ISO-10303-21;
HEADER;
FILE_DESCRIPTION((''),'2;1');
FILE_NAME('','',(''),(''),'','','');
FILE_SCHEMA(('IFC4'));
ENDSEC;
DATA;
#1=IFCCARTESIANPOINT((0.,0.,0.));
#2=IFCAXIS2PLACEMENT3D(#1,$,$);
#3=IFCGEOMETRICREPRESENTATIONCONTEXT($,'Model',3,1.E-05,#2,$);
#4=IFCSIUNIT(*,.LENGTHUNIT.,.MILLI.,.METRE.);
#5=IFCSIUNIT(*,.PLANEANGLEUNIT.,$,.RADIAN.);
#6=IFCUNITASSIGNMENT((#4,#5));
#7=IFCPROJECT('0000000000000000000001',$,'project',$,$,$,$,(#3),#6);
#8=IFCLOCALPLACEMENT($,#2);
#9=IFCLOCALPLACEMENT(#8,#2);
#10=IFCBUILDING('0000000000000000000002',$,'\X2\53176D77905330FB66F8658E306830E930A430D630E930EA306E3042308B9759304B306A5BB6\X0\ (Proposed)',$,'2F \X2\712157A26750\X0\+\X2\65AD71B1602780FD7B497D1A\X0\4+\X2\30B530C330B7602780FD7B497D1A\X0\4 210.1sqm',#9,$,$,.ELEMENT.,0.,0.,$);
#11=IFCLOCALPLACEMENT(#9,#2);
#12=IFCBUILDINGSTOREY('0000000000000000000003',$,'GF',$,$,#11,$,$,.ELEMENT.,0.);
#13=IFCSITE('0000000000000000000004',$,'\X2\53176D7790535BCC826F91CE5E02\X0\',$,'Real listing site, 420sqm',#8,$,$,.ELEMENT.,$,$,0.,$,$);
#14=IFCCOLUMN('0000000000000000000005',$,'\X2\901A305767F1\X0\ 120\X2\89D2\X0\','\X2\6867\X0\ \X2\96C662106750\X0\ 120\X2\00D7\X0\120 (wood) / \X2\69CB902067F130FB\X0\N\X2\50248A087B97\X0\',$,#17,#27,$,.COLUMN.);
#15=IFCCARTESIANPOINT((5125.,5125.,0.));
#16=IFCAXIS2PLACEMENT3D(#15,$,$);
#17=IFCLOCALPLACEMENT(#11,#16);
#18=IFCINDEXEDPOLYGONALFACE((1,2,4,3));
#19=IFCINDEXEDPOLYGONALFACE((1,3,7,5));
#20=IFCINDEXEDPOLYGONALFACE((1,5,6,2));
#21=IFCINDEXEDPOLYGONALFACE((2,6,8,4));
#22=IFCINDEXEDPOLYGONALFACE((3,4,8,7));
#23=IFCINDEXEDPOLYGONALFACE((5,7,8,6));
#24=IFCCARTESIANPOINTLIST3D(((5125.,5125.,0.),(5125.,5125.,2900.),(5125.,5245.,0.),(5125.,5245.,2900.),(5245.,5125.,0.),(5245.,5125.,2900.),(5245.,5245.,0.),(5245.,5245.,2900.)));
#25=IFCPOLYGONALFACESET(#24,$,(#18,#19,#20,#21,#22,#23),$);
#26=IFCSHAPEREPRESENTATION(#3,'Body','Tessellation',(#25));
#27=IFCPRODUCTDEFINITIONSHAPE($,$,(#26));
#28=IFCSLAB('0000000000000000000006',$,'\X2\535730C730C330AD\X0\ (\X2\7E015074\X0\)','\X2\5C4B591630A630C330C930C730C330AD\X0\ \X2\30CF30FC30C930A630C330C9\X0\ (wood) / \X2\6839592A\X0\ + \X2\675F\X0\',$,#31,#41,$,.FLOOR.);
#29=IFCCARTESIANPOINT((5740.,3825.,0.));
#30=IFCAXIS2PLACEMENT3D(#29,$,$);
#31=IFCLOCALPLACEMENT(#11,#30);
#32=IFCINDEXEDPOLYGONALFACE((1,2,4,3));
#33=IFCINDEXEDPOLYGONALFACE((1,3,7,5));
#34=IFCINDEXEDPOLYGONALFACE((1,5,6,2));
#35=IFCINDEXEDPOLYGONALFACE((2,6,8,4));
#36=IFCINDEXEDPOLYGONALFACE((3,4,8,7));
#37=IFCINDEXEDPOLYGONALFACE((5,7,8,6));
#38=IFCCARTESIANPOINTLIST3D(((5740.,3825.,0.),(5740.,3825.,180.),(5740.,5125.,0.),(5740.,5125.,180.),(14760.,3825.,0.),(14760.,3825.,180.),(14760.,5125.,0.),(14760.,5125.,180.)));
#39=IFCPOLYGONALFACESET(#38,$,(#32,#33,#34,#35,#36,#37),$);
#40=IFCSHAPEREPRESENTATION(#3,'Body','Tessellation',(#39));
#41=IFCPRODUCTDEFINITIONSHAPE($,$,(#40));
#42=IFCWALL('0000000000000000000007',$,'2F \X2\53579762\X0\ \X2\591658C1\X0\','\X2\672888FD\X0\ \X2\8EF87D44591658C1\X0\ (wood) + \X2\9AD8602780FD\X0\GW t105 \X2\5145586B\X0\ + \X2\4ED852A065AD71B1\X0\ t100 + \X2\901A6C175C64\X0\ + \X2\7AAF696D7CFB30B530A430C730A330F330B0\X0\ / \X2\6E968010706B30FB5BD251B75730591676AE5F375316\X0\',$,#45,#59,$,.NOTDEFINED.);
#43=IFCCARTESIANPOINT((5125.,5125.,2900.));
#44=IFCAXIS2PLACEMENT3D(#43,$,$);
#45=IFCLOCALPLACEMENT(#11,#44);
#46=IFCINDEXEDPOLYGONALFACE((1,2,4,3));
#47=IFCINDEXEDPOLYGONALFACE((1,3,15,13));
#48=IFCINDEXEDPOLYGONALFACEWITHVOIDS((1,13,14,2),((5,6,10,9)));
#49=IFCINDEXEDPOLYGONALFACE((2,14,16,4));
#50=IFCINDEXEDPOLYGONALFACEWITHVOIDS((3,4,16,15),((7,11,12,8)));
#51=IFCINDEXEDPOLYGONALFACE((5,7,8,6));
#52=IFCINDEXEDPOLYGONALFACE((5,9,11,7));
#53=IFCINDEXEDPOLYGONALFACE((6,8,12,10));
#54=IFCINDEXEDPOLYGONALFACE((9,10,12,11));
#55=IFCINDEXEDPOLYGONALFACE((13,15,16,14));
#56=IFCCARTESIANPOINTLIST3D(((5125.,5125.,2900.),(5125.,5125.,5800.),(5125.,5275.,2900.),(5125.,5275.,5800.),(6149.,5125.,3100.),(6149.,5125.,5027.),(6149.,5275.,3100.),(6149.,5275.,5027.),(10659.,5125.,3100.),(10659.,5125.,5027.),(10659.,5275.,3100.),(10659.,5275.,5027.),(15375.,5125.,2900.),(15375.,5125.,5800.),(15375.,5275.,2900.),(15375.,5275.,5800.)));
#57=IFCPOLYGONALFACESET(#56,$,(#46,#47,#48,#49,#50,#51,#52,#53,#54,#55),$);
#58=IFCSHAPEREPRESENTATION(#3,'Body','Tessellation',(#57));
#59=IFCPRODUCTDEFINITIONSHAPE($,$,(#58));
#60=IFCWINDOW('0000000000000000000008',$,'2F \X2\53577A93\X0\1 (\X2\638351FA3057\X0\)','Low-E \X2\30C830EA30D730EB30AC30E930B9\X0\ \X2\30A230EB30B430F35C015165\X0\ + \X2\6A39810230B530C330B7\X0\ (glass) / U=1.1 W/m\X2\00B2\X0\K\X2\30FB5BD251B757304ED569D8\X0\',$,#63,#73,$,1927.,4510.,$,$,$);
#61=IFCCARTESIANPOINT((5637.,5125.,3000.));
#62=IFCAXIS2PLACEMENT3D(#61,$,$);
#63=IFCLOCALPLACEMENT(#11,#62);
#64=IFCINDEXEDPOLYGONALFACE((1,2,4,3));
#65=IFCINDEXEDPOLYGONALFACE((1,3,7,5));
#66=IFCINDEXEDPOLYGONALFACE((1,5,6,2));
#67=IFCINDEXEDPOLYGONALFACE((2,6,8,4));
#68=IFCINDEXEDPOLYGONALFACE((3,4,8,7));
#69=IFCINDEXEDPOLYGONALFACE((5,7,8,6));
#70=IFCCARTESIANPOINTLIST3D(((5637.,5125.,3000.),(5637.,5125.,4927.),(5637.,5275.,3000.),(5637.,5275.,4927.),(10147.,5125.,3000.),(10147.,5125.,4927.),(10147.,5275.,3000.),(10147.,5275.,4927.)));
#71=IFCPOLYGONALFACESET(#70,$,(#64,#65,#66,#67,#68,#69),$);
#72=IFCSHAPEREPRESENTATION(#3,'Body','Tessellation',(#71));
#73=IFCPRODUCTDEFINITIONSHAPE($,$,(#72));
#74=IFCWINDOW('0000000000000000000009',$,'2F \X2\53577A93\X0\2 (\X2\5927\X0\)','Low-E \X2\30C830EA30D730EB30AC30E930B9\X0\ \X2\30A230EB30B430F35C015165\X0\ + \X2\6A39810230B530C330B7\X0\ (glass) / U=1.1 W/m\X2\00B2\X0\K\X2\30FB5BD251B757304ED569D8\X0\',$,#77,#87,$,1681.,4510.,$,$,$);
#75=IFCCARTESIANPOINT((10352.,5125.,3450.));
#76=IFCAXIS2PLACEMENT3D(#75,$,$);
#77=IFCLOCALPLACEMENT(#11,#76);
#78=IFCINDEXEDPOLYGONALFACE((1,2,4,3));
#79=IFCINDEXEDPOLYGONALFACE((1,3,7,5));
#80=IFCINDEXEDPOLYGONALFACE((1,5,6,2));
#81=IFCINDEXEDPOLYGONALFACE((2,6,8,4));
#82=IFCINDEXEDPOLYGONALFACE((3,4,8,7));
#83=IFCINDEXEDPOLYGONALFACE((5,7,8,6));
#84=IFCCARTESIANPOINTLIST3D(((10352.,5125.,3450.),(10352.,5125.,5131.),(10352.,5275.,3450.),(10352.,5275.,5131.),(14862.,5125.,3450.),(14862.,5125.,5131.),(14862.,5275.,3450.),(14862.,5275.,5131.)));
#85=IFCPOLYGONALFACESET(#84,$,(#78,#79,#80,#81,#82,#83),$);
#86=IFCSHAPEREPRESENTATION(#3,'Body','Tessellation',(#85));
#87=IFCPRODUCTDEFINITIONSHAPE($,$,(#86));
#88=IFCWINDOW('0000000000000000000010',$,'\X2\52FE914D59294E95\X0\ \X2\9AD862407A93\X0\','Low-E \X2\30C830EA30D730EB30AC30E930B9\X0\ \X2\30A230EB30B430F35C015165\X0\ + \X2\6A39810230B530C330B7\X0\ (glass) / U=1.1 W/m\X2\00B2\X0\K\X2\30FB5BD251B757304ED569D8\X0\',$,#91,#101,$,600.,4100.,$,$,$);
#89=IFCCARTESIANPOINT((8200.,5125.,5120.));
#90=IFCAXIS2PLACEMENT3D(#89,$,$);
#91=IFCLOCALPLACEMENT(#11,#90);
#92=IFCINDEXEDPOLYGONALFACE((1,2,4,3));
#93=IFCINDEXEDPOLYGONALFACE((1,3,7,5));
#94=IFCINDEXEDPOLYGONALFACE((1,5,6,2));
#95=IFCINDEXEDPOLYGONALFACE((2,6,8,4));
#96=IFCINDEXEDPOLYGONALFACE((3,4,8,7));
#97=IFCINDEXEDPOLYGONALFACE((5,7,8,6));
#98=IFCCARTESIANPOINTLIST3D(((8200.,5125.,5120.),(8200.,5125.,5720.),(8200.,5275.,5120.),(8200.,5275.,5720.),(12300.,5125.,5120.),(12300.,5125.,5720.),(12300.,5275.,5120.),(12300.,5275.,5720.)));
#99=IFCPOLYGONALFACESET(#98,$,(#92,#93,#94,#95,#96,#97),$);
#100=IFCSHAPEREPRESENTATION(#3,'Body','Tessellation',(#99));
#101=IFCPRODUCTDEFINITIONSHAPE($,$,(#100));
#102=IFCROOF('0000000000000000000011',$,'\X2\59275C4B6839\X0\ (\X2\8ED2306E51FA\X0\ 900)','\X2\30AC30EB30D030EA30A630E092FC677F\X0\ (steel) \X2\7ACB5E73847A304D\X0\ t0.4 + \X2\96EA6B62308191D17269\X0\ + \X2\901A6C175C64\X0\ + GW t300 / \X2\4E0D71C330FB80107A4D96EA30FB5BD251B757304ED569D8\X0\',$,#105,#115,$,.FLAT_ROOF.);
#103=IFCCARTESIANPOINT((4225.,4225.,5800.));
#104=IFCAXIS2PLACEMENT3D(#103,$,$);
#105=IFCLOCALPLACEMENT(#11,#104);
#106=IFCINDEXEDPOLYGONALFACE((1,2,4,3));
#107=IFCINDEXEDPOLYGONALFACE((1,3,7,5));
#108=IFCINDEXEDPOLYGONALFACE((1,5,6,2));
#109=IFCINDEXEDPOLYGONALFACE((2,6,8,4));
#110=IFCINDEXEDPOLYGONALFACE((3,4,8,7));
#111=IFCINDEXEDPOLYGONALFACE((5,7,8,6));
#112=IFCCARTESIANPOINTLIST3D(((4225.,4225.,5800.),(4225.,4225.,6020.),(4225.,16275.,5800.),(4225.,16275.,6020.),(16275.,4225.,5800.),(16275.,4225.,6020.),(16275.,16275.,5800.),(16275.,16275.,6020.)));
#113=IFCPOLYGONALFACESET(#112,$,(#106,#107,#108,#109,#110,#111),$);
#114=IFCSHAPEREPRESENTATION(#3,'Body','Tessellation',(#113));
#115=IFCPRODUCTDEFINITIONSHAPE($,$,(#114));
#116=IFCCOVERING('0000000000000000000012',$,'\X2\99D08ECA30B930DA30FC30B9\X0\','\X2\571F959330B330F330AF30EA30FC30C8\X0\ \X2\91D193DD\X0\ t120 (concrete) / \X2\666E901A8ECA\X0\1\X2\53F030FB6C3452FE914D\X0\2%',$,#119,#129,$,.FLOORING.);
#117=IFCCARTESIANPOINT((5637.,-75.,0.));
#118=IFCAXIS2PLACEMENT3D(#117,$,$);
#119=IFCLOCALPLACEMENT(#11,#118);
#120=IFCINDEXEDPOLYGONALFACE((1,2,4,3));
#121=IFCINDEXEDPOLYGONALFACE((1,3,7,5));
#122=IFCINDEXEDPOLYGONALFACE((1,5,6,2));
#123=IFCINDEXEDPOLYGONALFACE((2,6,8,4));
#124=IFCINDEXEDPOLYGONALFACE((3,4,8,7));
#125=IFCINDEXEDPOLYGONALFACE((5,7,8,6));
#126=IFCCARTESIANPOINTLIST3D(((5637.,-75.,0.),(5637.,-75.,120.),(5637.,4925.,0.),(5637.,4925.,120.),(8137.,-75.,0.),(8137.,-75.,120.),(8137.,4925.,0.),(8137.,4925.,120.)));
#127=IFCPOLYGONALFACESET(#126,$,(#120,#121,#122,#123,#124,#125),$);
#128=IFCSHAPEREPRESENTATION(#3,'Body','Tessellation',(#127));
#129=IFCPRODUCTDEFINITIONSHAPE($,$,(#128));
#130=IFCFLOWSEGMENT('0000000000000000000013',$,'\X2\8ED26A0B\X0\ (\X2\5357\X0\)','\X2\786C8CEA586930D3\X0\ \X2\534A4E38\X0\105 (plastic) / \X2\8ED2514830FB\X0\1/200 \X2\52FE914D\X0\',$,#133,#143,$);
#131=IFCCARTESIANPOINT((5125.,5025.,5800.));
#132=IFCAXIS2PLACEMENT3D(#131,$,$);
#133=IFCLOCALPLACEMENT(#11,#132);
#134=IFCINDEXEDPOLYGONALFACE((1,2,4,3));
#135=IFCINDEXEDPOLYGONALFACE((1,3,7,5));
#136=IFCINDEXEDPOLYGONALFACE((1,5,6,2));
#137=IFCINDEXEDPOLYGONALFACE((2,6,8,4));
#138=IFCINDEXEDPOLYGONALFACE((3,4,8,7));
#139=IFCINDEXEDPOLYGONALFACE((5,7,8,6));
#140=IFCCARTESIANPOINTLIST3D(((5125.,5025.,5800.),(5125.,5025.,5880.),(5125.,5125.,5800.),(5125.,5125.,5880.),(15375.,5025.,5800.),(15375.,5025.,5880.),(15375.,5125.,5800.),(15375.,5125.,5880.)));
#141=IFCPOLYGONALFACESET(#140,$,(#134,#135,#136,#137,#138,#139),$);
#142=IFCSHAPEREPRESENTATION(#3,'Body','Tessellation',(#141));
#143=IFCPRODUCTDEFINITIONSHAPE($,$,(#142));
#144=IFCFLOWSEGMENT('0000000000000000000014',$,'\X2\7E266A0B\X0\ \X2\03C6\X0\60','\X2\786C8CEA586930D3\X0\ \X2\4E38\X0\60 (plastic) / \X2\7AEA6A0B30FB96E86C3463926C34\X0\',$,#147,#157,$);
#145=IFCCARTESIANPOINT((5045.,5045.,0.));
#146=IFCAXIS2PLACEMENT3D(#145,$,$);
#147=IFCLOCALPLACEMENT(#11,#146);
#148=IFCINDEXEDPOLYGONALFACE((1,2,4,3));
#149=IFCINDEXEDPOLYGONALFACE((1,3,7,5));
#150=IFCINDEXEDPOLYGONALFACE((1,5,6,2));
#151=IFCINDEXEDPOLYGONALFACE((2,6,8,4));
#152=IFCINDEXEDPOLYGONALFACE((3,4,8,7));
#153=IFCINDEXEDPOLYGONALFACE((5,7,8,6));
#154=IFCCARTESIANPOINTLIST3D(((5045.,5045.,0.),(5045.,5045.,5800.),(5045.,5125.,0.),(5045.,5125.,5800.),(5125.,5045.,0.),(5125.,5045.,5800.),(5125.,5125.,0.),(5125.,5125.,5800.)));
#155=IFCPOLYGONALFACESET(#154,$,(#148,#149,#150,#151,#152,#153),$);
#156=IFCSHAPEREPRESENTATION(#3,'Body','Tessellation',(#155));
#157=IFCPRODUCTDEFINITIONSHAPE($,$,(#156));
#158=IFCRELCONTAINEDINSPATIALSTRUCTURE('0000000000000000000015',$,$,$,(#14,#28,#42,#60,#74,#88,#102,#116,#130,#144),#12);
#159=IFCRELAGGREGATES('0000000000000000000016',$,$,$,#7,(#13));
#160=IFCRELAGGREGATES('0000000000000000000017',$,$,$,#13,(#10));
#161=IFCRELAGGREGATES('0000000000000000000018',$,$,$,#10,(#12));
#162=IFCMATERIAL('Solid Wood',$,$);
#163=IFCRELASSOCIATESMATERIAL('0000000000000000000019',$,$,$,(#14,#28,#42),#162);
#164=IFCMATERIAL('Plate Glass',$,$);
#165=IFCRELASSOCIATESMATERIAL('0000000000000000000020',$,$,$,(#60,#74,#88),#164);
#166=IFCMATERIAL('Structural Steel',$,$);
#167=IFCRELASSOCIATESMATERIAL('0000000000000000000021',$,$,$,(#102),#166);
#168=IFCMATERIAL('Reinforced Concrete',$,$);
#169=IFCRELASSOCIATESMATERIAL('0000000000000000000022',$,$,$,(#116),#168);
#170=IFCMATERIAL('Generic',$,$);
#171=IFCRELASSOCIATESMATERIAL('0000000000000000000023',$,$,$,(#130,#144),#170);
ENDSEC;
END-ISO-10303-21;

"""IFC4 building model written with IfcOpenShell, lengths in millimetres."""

from ifc_helpers import new_model, si_unit, frame, frame_2d, origin, place, context, project, spatial, rectangle, extrude, material, element, fill, save


model = new_model("IFC4")

# Units and contexts
model_context = context("Model", 3, precision=1e-05, world=origin())
ifc_project = project(units=[si_unit("LENGTHUNIT", "METRE", prefix="MILLI"), si_unit("PLANEANGLEUNIT", "RADIAN")], contexts=[model_context])

# Site, building, storey
site_placement = place(None, origin())
site = spatial("IfcSite", under=ifc_project, at=site_placement, Name="北海道富良野市", ObjectType="Real listing site, 420sqm", CompositionType="ELEMENT", RefElevation=0.0)
building_placement = place(site_placement, origin())
building = spatial("IfcBuilding", under=site, at=building_placement, Name="北海道・書斎とライブラリのある静かな家 (Proposed)", ObjectType="2F 無垢材+断熱性能等級4+サッシ性能等級4 210.1sqm", CompositionType="ELEMENT", ElevationOfRefHeight=0.0, ElevationOfTerrain=0.0)
storey_placement = place(building_placement, origin())
storey = spatial("IfcBuildingStorey", under=building, at=storey_placement, Name="GF", CompositionType="ELEMENT", Elevation=0.0)

# Column
ifc_material_1 = material(Name="Solid Wood")
column_placement = place(storey_placement, frame((5125.0, 5125.0, 0.0)))
element("IfcColumn", 1, at=column_placement, inside=storey, material=ifc_material_1, Name="通し柱 120角", Description="桧 集成材 120×120 (wood) / 構造柱・N値計算", PredefinedType="COLUMN", context=model_context, shape_type="SweptSolid", body=[
    extrude(rectangle(XDim=120.0, YDim=120.0, at=frame_2d((60.0, 60.0))), frame((5125.0, 5125.0, 0.0)), (0.0, 0.0, 1.0), 2900.0),
])

# Slab
ifc_material_2 = material(Name="Reinforced Concrete")
slab_1_placement = place(storey_placement, frame((5740.0, 3825.0, 0.0)))
element("IfcSlab", 2, at=slab_1_placement, inside=storey, material=ifc_material_1, Name="南デッキ (縁側)", Description="屋外ウッドデッキ ハードウッド (wood) / 根太 + 束", PredefinedType="FLOOR", context=model_context, shape_type="SweptSolid", body=[
    extrude(rectangle(XDim=9020.0, YDim=1300.0, at=frame_2d((4510.0, 650.0))), frame((5740.0, 3825.0, 0.0)), (0.0, 0.0, 1.0), 180.0),
])

# Shared definitions
ifc_material_3 = material(Name="Plate Glass")

# Wall, openings, windows
wall_1_placement = place(storey_placement, frame((5125.0, 5125.0, 2900.0)))
wall_1 = element("IfcWall", 3, at=wall_1_placement, inside=storey, material=ifc_material_1, Name="2F 南面 外壁", Description="木製 軸組外壁 (wood) + 高性能GW t105 充填 + 付加断熱 t100 + 通気層 + 窯業系サイディング / 準耐火・寒冷地外皮強化", PredefinedType="NOTDEFINED", context=model_context, shape_type="SweptSolid", body=[
    extrude(rectangle(XDim=10250.0, YDim=150.0, at=frame_2d((5125.0, 75.0))), frame((5125.0, 5125.0, 2900.0)), (0.0, 0.0, 1.0), 2900.0),
])
opening_1_placement = place(storey_placement, frame((5637.0, 5125.0, 3000.0)))
opening_1 = element("IfcOpeningElement", 4, at=opening_1_placement, cuts=wall_1, PredefinedType="NOTDEFINED", context=model_context, shape_type="SweptSolid", body=[
    extrude(rectangle(XDim=4510.0, YDim=150.0, at=frame_2d((2255.0, 75.0))), frame((5637.0, 5125.0, 3000.0)), (0.0, 0.0, 1.0), 1927.0),
])
opening_2_placement = place(storey_placement, frame((10352.0, 5125.0, 3450.0)))
opening_2 = element("IfcOpeningElement", 5, at=opening_2_placement, cuts=wall_1, PredefinedType="NOTDEFINED", context=model_context, shape_type="SweptSolid", body=[
    extrude(rectangle(XDim=4510.0, YDim=150.0, at=frame_2d((2255.0, 75.0))), frame((10352.0, 5125.0, 3450.0)), (0.0, 0.0, 1.0), 1681.0),
])
opening_3_placement = place(storey_placement, frame((8200.0, 5125.0, 5120.0)))
opening_3 = element("IfcOpeningElement", 6, at=opening_3_placement, cuts=wall_1, PredefinedType="NOTDEFINED", context=model_context, shape_type="SweptSolid", body=[
    extrude(rectangle(XDim=4100.0, YDim=150.0, at=frame_2d((2050.0, 75.0))), frame((8200.0, 5125.0, 5120.0)), (0.0, 0.0, 1.0), 600.0),
])
window_1_placement = place(storey_placement, frame((5637.0, 5125.0, 3000.0)))
window_1 = element("IfcWindow", 7, at=window_1_placement, inside=storey, material=ifc_material_3, Name="2F 南窓1 (掃出し)", Description="Low-E トリプルガラス アルゴン封入 + 樹脂サッシ (glass) / U=1.1 W/m²K・寒冷地仕様", OverallHeight=1927.0, OverallWidth=4510.0, context=model_context, shape_type="SweptSolid", body=[
    extrude(rectangle(XDim=4510.0, YDim=150.0, at=frame_2d((2255.0, 75.0))), frame((5637.0, 5125.0, 3000.0)), (0.0, 0.0, 1.0), 1927.0),
])
fill(opening_1, window_1)
window_2_placement = place(storey_placement, frame((10352.0, 5125.0, 3450.0)))
window_2 = element("IfcWindow", 8, at=window_2_placement, inside=storey, material=ifc_material_3, Name="2F 南窓2 (大)", Description="Low-E トリプルガラス アルゴン封入 + 樹脂サッシ (glass) / U=1.1 W/m²K・寒冷地仕様", OverallHeight=1681.0, OverallWidth=4510.0, context=model_context, shape_type="SweptSolid", body=[
    extrude(rectangle(XDim=4510.0, YDim=150.0, at=frame_2d((2255.0, 75.0))), frame((10352.0, 5125.0, 3450.0)), (0.0, 0.0, 1.0), 1681.0),
])
fill(opening_2, window_2)
window_3_placement = place(storey_placement, frame((8200.0, 5125.0, 5120.0)))
window_3 = element("IfcWindow", 9, at=window_3_placement, inside=storey, material=ifc_material_3, Name="勾配天井 高所窓", Description="Low-E トリプルガラス アルゴン封入 + 樹脂サッシ (glass) / U=1.1 W/m²K・寒冷地仕様", OverallHeight=600.0, OverallWidth=4100.0, context=model_context, shape_type="SweptSolid", body=[
    extrude(rectangle(XDim=4100.0, YDim=150.0, at=frame_2d((2050.0, 75.0))), frame((8200.0, 5125.0, 5120.0)), (0.0, 0.0, 1.0), 600.0),
])
fill(opening_3, window_3)

# Roof
ifc_material_4 = material(Name="Structural Steel")
roof_placement = place(storey_placement, frame((4225.0, 4225.0, 5800.0)))
element("IfcRoof", 10, at=roof_placement, inside=storey, material=ifc_material_4, Name="大屋根 (軒の出 900)", Description="ガルバリウム鋼板 (steel) 立平葺き t0.4 + 雪止め金物 + 通気層 + GW t300 / 不燃・耐積雪・寒冷地仕様", PredefinedType="FLAT_ROOF", context=model_context, shape_type="SweptSolid", body=[
    extrude(rectangle(XDim=12050.0, YDim=12050.0, at=frame_2d((6025.0, 6025.0))), frame((4225.0, 4225.0, 5800.0)), (0.0, 0.0, 1.0), 220.0),
])

# Covering
covering_placement = place(storey_placement, frame((5637.0, -75.0, 0.0)))
element("IfcCovering", 11, at=covering_placement, inside=storey, material=ifc_material_2, Name="駐車スペース", Description="土間コンクリート 金鏝 t120 (concrete) / 普通車1台・水勾配2%", PredefinedType="FLOORING", context=model_context, shape_type="SweptSolid", body=[
    extrude(rectangle(XDim=2500.0, YDim=5000.0, at=frame_2d((1250.0, 2500.0))), frame((5637.0, -75.0, 0.0)), (0.0, 0.0, 1.0), 120.0),
])

# Flow segments
ifc_material_5 = material(Name="Generic")
flow_segment_1_placement = place(storey_placement, frame((5125.0, 5025.0, 5800.0)))
element("IfcFlowSegment", 12, at=flow_segment_1_placement, inside=storey, material=ifc_material_5, Name="軒樋 (南)", Description="硬質塩ビ 半丸105 (plastic) / 軒先・1/200 勾配", context=model_context, shape_type="SweptSolid", body=[
    extrude(rectangle(XDim=10250.0, YDim=100.0, at=frame_2d((5125.0, 50.0))), frame((5125.0, 5025.0, 5800.0)), (0.0, 0.0, 1.0), 80.0),
])
flow_segment_2_placement = place(storey_placement, frame((5045.0, 5045.0, 0.0)))
element("IfcFlowSegment", 13, at=flow_segment_2_placement, inside=storey, material=ifc_material_5, Name="縦樋 φ60", Description="硬質塩ビ 丸60 (plastic) / 竪樋・雨水排水", context=model_context, shape_type="SweptSolid", body=[
    extrude(rectangle(XDim=80.0, YDim=80.0, at=frame_2d((40.0, 40.0))), frame((5045.0, 5045.0, 0.0)), (0.0, 0.0, 1.0), 5800.0),
])

save(model, "model.ifc")
